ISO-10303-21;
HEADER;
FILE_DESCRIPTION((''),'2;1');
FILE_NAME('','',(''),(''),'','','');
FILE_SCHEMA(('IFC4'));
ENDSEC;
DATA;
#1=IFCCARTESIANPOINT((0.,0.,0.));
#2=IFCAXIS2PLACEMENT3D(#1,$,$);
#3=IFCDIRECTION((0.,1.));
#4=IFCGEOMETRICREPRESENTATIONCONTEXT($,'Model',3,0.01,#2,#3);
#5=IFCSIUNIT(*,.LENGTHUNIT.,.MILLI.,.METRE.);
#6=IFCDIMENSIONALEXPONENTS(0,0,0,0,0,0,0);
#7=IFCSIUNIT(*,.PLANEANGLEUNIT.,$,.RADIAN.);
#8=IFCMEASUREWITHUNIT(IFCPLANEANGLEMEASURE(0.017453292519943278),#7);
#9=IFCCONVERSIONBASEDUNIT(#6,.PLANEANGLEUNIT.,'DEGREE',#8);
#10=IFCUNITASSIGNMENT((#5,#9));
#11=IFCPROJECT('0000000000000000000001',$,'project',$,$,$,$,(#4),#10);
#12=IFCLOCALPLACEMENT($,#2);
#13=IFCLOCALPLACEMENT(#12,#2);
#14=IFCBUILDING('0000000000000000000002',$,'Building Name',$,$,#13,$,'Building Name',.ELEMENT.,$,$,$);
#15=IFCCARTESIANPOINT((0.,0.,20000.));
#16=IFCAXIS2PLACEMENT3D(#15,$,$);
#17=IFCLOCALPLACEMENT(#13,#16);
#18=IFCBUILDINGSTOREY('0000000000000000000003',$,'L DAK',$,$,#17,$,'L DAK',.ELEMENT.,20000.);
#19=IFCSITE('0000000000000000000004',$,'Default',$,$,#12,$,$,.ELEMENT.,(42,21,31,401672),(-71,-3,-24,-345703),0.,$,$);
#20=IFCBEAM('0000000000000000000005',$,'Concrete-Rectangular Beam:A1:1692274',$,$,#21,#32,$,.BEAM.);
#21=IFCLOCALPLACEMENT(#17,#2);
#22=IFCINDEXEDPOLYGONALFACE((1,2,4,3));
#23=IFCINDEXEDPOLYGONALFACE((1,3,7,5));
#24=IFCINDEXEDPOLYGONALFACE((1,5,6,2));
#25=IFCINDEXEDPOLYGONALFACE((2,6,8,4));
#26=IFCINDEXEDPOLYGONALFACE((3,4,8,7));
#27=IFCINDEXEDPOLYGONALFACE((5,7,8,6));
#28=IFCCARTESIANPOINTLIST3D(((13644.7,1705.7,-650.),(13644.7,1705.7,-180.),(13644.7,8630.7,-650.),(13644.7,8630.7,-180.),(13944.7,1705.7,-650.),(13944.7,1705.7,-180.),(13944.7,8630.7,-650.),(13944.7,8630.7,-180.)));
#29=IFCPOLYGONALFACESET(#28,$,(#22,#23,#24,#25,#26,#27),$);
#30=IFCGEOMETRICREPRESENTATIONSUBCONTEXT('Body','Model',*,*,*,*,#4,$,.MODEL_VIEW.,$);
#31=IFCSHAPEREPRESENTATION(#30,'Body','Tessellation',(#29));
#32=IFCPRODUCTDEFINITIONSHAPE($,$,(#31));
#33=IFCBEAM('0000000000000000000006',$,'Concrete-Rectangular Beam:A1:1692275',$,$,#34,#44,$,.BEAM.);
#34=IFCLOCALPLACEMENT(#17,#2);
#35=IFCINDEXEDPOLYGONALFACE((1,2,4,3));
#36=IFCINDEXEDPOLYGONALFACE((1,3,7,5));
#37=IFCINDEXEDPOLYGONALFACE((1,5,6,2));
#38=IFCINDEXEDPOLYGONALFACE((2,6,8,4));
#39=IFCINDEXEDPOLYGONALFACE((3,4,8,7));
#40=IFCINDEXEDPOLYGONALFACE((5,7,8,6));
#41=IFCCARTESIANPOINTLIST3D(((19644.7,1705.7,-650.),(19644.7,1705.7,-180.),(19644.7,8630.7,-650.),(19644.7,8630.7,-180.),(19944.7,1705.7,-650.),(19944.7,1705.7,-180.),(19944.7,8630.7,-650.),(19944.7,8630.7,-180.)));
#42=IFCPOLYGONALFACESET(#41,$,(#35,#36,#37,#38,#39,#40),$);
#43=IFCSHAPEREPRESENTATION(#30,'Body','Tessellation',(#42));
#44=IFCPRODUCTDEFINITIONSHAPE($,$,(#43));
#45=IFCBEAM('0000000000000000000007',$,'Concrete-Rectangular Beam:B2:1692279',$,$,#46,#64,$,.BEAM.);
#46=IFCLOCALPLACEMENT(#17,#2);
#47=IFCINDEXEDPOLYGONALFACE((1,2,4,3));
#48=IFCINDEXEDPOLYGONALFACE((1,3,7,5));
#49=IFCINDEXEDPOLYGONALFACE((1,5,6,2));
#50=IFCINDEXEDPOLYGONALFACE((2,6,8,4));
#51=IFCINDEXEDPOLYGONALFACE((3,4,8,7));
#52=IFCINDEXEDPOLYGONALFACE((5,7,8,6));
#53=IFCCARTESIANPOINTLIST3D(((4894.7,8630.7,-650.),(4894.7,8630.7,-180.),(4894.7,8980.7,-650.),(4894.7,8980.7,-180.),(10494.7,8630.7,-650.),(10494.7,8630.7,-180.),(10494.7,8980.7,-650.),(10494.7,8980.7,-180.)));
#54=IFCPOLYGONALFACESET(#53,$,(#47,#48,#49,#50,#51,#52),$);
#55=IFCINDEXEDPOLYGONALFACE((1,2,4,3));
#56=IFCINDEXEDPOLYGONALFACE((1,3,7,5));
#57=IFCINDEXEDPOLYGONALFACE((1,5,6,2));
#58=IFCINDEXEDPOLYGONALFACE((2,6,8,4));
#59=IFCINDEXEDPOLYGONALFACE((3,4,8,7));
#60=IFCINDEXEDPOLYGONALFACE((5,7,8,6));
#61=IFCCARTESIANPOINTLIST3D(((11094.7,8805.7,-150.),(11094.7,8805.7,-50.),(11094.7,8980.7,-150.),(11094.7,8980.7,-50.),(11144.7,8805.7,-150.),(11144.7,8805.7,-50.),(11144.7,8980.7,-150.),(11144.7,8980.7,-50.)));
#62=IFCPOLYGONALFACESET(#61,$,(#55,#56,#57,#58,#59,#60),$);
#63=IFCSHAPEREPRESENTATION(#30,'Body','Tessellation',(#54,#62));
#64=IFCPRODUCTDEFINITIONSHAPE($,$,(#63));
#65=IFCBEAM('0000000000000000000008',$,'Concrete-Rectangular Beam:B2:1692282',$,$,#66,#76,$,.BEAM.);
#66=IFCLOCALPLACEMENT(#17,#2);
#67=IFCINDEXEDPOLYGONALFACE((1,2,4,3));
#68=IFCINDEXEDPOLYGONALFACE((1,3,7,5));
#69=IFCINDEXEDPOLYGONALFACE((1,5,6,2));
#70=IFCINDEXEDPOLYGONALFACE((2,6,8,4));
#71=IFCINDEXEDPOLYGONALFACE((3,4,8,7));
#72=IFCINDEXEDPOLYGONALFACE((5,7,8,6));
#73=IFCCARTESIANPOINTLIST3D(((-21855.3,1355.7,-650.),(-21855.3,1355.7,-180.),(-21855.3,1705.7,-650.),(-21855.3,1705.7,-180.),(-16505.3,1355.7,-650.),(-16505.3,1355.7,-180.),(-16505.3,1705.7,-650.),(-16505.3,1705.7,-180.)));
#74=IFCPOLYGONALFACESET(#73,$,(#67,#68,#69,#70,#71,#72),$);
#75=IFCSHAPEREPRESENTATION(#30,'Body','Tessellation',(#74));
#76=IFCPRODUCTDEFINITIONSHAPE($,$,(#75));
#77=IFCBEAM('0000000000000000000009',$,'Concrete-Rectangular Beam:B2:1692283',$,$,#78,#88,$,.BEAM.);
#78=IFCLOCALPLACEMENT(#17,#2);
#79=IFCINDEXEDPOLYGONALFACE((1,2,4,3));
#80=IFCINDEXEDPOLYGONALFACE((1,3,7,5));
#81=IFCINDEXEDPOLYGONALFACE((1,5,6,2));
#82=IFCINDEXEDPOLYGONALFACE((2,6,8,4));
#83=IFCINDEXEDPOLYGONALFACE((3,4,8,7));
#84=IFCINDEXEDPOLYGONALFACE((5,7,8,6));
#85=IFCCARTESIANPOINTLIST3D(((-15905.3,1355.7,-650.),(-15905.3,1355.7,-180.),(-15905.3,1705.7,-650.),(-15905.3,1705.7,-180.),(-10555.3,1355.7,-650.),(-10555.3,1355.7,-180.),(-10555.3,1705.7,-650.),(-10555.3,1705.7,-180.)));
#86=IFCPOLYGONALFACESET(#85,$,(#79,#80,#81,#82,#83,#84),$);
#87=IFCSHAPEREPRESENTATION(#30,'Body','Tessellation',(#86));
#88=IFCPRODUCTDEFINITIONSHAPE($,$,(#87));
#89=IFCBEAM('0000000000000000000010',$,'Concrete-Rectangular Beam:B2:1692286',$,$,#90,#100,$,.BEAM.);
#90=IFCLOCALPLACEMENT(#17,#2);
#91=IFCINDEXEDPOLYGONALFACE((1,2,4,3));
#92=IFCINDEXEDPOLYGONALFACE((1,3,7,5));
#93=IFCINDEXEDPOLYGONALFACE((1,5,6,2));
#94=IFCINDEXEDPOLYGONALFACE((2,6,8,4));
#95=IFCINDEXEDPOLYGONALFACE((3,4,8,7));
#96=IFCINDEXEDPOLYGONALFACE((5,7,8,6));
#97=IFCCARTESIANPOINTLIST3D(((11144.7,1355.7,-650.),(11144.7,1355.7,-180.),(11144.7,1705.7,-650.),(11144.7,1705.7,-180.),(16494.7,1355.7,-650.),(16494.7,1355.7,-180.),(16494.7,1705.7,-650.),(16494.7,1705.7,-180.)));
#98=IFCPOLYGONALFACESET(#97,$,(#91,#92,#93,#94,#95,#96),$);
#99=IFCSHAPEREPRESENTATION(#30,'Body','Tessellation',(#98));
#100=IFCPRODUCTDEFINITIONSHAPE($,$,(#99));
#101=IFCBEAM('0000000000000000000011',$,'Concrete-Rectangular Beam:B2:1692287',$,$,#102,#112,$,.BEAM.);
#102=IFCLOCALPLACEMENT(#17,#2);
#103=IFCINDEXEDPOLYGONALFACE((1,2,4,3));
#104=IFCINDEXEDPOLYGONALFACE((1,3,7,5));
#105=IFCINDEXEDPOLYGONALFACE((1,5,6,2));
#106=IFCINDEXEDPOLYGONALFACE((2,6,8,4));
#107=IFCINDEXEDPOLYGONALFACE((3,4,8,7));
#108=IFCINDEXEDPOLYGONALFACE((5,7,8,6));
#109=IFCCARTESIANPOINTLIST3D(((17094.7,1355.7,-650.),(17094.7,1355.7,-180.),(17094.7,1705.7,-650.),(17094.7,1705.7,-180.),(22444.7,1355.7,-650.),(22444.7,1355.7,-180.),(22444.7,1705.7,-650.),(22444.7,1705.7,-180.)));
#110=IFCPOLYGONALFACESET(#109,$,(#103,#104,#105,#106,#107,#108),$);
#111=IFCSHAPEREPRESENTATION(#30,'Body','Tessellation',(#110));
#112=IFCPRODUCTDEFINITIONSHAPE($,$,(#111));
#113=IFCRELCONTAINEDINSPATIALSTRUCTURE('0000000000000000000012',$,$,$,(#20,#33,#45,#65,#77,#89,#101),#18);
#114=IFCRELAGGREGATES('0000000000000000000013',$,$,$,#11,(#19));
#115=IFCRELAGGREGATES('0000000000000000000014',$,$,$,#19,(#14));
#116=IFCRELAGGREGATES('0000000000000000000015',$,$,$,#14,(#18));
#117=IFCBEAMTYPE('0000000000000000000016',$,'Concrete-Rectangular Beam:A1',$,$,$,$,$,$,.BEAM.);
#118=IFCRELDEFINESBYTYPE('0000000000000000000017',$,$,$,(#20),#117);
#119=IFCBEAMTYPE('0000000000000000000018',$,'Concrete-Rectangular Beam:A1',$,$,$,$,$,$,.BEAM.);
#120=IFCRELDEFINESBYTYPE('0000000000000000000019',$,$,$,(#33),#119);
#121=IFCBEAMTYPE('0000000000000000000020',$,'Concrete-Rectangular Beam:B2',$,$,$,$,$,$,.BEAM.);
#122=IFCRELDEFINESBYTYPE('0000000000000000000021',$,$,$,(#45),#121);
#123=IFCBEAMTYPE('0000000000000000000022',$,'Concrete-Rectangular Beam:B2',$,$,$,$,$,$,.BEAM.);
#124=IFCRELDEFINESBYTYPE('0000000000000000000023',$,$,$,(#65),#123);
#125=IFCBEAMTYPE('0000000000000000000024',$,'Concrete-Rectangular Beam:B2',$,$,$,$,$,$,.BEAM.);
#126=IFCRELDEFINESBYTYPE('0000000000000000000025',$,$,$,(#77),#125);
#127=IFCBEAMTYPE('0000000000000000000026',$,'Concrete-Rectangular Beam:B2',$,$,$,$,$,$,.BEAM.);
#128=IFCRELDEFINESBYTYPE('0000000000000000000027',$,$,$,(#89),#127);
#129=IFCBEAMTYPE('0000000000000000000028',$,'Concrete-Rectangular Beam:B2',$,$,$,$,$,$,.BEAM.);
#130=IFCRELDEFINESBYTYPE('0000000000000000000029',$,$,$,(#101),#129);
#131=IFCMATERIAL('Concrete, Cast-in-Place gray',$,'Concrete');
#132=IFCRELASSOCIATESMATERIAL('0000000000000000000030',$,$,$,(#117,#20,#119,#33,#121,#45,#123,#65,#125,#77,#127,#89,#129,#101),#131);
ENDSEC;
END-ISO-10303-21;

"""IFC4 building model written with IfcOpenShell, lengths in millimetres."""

from ifc_helpers import new_model, entity, si_unit, converted_unit, direction, frame, origin, place, context, subcontext, project, spatial, indexed_curve, outline, extrude, source, transform, mapped, material, type_object, type_shapes, element, save


model = new_model("IFC4")

# Units and contexts
model_context = context("Model", 3, precision=0.01, world=origin(), true_north=direction((0.0, 1.0)))
body_context = subcontext(model_context, "Body", "Model", "MODEL_VIEW")
ifc_project = project(units=[si_unit("LENGTHUNIT", "METRE", prefix="MILLI"), converted_unit("PLANEANGLEUNIT", "DEGREE", entity("IfcPlaneAngleMeasure", 0.017453292519943278), si_unit("PLANEANGLEUNIT", "RADIAN"), dimensions=[0, 0, 0, 0, 0, 0, 0])], contexts=[model_context])

# Site, building, storey
site_placement = place(None, origin())
site = spatial("IfcSite", under=ifc_project, at=site_placement, Name="Default", CompositionType="ELEMENT", RefLatitude=(42, 21, 31, 401672), RefLongitude=(-71, -3, -24, -345703), RefElevation=0.0)
building_placement = place(site_placement, origin())
building = spatial("IfcBuilding", under=site, at=building_placement, Name="Building Name", LongName="Building Name", CompositionType="ELEMENT")
storey_placement = place(building_placement, frame((0.0, 0.0, 20000.0)))
storey = spatial("IfcBuildingStorey", under=building, at=storey_placement, Name="L DAK", LongName="L DAK", CompositionType="ELEMENT", Elevation=20000.0)

# Beams
ifc_material = material(Name="Concrete, Cast-in-Place gray", Category="Concrete")
beam_type_1 = type_object("IfcBeamType", Name="Concrete-Rectangular Beam:A1", PredefinedType="BEAM", material=ifc_material)
shared_shape_1 = source(origin(), body_context, "Body", "SweptSolid", [
    extrude(outline(indexed_curve([(-150.0, -235.0), (150.0, -235.0), (150.0, 235.0), (-150.0, 235.0), (-150.0, -235.0)], self_intersect=False)), frame((13794.7, 8630.7, 19585.0), z_axis=(0.0, -1.0, 0.0), x_axis=(-1.0, 0.0, 0.0)), (0.0, 0.0, 1.0), 6925.0),
])
type_shapes(beam_type_1, [shared_shape_1])
beam_1_placement = place(storey_placement, frame((0.0, 0.0, -20000.0)))
element("IfcBeam", 1, at=beam_1_placement, inside=storey, type_object=beam_type_1, material=ifc_material, Name="Concrete-Rectangular Beam:A1:1692274", PredefinedType="BEAM", context=body_context, shape_type="MappedRepresentation", body=[
    mapped(shared_shape_1, transform((0.0, 0.0, 0.0), scale=1.0)),
])
beam_type_2 = type_object("IfcBeamType", Name="Concrete-Rectangular Beam:A1", PredefinedType="BEAM", material=ifc_material)
shared_shape_2 = source(origin(), body_context, "Body", "SweptSolid", [
    extrude(outline(indexed_curve([(-150.0, -235.0), (150.0, -235.0), (150.0, 235.0), (-150.0, 235.0), (-150.0, -235.0)], self_intersect=False)), frame((19794.7, 8630.7, 19585.0), z_axis=(0.0, -1.0, 0.0), x_axis=(-1.0, 0.0, 0.0)), (0.0, 0.0, 1.0), 6925.0),
])
type_shapes(beam_type_2, [shared_shape_2])
beam_2_placement = place(storey_placement, frame((0.0, 0.0, -20000.0)))
element("IfcBeam", 2, at=beam_2_placement, inside=storey, type_object=beam_type_2, material=ifc_material, Name="Concrete-Rectangular Beam:A1:1692275", PredefinedType="BEAM", context=body_context, shape_type="MappedRepresentation", body=[
    mapped(shared_shape_2, transform((0.0, 0.0, 0.0), scale=1.0)),
])
beam_type_3 = type_object("IfcBeamType", Name="Concrete-Rectangular Beam:B2", PredefinedType="BEAM", material=ifc_material)
shared_shape_3 = source(origin(), body_context, "Body", "SweptSolid", [
    extrude(outline(indexed_curve([(-235.0, -175.0), (235.0, -175.0), (235.0, 175.0), (-235.0, 175.0), (-235.0, -175.0)], self_intersect=False)), frame((4894.7, 8805.7, 19585.0), z_axis=(1.0, 0.0, 0.0), x_axis=(0.0, 0.0, -1.0)), (0.0, 0.0, 1.0), 5600.0),
    extrude(outline(indexed_curve([(-50.0, -87.5), (50.0, -87.5), (50.0, 87.5), (-50.0, 87.5), (-50.0, -87.5)], self_intersect=False)), frame((11094.7, 8893.2, 19900.0), z_axis=(1.0, 0.0, 0.0), x_axis=(0.0, 0.0, -1.0)), (0.0, 0.0, 1.0), 50.0),
])
type_shapes(beam_type_3, [shared_shape_3])
beam_3_placement = place(storey_placement, frame((0.0, 0.0, -20000.0)))
element("IfcBeam", 3, at=beam_3_placement, inside=storey, type_object=beam_type_3, material=ifc_material, Name="Concrete-Rectangular Beam:B2:1692279", PredefinedType="BEAM", context=body_context, shape_type="MappedRepresentation", body=[
    mapped(shared_shape_3, transform((0.0, 0.0, 0.0), scale=1.0)),
])
beam_type_4 = type_object("IfcBeamType", Name="Concrete-Rectangular Beam:B2", PredefinedType="BEAM", material=ifc_material)
shared_shape_4 = source(origin(), body_context, "Body", "SweptSolid", [
    extrude(outline(indexed_curve([(-235.0, -175.0), (235.0, -175.0), (235.0, 175.0), (-235.0, 175.0), (-235.0, -175.0)], self_intersect=False)), frame((-21855.3, 1530.7, 19585.0), z_axis=(1.0, 0.0, 0.0), x_axis=(0.0, 0.0, -1.0)), (0.0, 0.0, 1.0), 5350.0),
])
type_shapes(beam_type_4, [shared_shape_4])
beam_4_placement = place(storey_placement, frame((0.0, 0.0, -20000.0)))
element("IfcBeam", 4, at=beam_4_placement, inside=storey, type_object=beam_type_4, material=ifc_material, Name="Concrete-Rectangular Beam:B2:1692282", PredefinedType="BEAM", context=body_context, shape_type="MappedRepresentation", body=[
    mapped(shared_shape_4, transform((0.0, 0.0, 0.0), scale=1.0)),
])
beam_type_5 = type_object("IfcBeamType", Name="Concrete-Rectangular Beam:B2", PredefinedType="BEAM", material=ifc_material)
shared_shape_5 = source(origin(), body_context, "Body", "SweptSolid", [
    extrude(outline(indexed_curve([(-235.0, -175.0), (235.0, -175.0), (235.0, 175.0), (-235.0, 175.0), (-235.0, -175.0)], self_intersect=False)), frame((-15905.3, 1530.7, 19585.0), z_axis=(1.0, 0.0, 0.0), x_axis=(0.0, 0.0, -1.0)), (0.0, 0.0, 1.0), 5350.0),
])
type_shapes(beam_type_5, [shared_shape_5])
beam_5_placement = place(storey_placement, frame((0.0, 0.0, -20000.0)))
element("IfcBeam", 5, at=beam_5_placement, inside=storey, type_object=beam_type_5, material=ifc_material, Name="Concrete-Rectangular Beam:B2:1692283", PredefinedType="BEAM", context=body_context, shape_type="MappedRepresentation", body=[
    mapped(shared_shape_5, transform((0.0, 0.0, 0.0), scale=1.0)),
])
beam_type_6 = type_object("IfcBeamType", Name="Concrete-Rectangular Beam:B2", PredefinedType="BEAM", material=ifc_material)
shared_shape_6 = source(origin(), body_context, "Body", "SweptSolid", [
    extrude(outline(indexed_curve([(-235.0, -175.0), (235.0, -175.0), (235.0, 175.0), (-235.0, 175.0), (-235.0, -175.0)], self_intersect=False)), frame((11144.7, 1530.7, 19585.0), z_axis=(1.0, 0.0, 0.0), x_axis=(0.0, 0.0, -1.0)), (0.0, 0.0, 1.0), 5350.0),
])
type_shapes(beam_type_6, [shared_shape_6])
beam_6_placement = place(storey_placement, frame((0.0, 0.0, -20000.0)))
element("IfcBeam", 6, at=beam_6_placement, inside=storey, type_object=beam_type_6, material=ifc_material, Name="Concrete-Rectangular Beam:B2:1692286", PredefinedType="BEAM", context=body_context, shape_type="MappedRepresentation", body=[
    mapped(shared_shape_6, transform((0.0, 0.0, 0.0), scale=1.0)),
])
beam_type_7 = type_object("IfcBeamType", Name="Concrete-Rectangular Beam:B2", PredefinedType="BEAM", material=ifc_material)
shared_shape_7 = source(origin(), body_context, "Body", "SweptSolid", [
    extrude(outline(indexed_curve([(-235.0, -175.0), (235.0, -175.0), (235.0, 175.0), (-235.0, 175.0), (-235.0, -175.0)], self_intersect=False)), frame((17094.7, 1530.7, 19585.0), z_axis=(1.0, 0.0, 0.0), x_axis=(0.0, 0.0, -1.0)), (0.0, 0.0, 1.0), 5350.0),
])
type_shapes(beam_type_7, [shared_shape_7])
beam_7_placement = place(storey_placement, frame((0.0, 0.0, -20000.0)))
element("IfcBeam", 7, at=beam_7_placement, inside=storey, type_object=beam_type_7, material=ifc_material, Name="Concrete-Rectangular Beam:B2:1692287", PredefinedType="BEAM", context=body_context, shape_type="MappedRepresentation", body=[
    mapped(shared_shape_7, transform((0.0, 0.0, 0.0), scale=1.0)),
])

save(model, "model.ifc")
